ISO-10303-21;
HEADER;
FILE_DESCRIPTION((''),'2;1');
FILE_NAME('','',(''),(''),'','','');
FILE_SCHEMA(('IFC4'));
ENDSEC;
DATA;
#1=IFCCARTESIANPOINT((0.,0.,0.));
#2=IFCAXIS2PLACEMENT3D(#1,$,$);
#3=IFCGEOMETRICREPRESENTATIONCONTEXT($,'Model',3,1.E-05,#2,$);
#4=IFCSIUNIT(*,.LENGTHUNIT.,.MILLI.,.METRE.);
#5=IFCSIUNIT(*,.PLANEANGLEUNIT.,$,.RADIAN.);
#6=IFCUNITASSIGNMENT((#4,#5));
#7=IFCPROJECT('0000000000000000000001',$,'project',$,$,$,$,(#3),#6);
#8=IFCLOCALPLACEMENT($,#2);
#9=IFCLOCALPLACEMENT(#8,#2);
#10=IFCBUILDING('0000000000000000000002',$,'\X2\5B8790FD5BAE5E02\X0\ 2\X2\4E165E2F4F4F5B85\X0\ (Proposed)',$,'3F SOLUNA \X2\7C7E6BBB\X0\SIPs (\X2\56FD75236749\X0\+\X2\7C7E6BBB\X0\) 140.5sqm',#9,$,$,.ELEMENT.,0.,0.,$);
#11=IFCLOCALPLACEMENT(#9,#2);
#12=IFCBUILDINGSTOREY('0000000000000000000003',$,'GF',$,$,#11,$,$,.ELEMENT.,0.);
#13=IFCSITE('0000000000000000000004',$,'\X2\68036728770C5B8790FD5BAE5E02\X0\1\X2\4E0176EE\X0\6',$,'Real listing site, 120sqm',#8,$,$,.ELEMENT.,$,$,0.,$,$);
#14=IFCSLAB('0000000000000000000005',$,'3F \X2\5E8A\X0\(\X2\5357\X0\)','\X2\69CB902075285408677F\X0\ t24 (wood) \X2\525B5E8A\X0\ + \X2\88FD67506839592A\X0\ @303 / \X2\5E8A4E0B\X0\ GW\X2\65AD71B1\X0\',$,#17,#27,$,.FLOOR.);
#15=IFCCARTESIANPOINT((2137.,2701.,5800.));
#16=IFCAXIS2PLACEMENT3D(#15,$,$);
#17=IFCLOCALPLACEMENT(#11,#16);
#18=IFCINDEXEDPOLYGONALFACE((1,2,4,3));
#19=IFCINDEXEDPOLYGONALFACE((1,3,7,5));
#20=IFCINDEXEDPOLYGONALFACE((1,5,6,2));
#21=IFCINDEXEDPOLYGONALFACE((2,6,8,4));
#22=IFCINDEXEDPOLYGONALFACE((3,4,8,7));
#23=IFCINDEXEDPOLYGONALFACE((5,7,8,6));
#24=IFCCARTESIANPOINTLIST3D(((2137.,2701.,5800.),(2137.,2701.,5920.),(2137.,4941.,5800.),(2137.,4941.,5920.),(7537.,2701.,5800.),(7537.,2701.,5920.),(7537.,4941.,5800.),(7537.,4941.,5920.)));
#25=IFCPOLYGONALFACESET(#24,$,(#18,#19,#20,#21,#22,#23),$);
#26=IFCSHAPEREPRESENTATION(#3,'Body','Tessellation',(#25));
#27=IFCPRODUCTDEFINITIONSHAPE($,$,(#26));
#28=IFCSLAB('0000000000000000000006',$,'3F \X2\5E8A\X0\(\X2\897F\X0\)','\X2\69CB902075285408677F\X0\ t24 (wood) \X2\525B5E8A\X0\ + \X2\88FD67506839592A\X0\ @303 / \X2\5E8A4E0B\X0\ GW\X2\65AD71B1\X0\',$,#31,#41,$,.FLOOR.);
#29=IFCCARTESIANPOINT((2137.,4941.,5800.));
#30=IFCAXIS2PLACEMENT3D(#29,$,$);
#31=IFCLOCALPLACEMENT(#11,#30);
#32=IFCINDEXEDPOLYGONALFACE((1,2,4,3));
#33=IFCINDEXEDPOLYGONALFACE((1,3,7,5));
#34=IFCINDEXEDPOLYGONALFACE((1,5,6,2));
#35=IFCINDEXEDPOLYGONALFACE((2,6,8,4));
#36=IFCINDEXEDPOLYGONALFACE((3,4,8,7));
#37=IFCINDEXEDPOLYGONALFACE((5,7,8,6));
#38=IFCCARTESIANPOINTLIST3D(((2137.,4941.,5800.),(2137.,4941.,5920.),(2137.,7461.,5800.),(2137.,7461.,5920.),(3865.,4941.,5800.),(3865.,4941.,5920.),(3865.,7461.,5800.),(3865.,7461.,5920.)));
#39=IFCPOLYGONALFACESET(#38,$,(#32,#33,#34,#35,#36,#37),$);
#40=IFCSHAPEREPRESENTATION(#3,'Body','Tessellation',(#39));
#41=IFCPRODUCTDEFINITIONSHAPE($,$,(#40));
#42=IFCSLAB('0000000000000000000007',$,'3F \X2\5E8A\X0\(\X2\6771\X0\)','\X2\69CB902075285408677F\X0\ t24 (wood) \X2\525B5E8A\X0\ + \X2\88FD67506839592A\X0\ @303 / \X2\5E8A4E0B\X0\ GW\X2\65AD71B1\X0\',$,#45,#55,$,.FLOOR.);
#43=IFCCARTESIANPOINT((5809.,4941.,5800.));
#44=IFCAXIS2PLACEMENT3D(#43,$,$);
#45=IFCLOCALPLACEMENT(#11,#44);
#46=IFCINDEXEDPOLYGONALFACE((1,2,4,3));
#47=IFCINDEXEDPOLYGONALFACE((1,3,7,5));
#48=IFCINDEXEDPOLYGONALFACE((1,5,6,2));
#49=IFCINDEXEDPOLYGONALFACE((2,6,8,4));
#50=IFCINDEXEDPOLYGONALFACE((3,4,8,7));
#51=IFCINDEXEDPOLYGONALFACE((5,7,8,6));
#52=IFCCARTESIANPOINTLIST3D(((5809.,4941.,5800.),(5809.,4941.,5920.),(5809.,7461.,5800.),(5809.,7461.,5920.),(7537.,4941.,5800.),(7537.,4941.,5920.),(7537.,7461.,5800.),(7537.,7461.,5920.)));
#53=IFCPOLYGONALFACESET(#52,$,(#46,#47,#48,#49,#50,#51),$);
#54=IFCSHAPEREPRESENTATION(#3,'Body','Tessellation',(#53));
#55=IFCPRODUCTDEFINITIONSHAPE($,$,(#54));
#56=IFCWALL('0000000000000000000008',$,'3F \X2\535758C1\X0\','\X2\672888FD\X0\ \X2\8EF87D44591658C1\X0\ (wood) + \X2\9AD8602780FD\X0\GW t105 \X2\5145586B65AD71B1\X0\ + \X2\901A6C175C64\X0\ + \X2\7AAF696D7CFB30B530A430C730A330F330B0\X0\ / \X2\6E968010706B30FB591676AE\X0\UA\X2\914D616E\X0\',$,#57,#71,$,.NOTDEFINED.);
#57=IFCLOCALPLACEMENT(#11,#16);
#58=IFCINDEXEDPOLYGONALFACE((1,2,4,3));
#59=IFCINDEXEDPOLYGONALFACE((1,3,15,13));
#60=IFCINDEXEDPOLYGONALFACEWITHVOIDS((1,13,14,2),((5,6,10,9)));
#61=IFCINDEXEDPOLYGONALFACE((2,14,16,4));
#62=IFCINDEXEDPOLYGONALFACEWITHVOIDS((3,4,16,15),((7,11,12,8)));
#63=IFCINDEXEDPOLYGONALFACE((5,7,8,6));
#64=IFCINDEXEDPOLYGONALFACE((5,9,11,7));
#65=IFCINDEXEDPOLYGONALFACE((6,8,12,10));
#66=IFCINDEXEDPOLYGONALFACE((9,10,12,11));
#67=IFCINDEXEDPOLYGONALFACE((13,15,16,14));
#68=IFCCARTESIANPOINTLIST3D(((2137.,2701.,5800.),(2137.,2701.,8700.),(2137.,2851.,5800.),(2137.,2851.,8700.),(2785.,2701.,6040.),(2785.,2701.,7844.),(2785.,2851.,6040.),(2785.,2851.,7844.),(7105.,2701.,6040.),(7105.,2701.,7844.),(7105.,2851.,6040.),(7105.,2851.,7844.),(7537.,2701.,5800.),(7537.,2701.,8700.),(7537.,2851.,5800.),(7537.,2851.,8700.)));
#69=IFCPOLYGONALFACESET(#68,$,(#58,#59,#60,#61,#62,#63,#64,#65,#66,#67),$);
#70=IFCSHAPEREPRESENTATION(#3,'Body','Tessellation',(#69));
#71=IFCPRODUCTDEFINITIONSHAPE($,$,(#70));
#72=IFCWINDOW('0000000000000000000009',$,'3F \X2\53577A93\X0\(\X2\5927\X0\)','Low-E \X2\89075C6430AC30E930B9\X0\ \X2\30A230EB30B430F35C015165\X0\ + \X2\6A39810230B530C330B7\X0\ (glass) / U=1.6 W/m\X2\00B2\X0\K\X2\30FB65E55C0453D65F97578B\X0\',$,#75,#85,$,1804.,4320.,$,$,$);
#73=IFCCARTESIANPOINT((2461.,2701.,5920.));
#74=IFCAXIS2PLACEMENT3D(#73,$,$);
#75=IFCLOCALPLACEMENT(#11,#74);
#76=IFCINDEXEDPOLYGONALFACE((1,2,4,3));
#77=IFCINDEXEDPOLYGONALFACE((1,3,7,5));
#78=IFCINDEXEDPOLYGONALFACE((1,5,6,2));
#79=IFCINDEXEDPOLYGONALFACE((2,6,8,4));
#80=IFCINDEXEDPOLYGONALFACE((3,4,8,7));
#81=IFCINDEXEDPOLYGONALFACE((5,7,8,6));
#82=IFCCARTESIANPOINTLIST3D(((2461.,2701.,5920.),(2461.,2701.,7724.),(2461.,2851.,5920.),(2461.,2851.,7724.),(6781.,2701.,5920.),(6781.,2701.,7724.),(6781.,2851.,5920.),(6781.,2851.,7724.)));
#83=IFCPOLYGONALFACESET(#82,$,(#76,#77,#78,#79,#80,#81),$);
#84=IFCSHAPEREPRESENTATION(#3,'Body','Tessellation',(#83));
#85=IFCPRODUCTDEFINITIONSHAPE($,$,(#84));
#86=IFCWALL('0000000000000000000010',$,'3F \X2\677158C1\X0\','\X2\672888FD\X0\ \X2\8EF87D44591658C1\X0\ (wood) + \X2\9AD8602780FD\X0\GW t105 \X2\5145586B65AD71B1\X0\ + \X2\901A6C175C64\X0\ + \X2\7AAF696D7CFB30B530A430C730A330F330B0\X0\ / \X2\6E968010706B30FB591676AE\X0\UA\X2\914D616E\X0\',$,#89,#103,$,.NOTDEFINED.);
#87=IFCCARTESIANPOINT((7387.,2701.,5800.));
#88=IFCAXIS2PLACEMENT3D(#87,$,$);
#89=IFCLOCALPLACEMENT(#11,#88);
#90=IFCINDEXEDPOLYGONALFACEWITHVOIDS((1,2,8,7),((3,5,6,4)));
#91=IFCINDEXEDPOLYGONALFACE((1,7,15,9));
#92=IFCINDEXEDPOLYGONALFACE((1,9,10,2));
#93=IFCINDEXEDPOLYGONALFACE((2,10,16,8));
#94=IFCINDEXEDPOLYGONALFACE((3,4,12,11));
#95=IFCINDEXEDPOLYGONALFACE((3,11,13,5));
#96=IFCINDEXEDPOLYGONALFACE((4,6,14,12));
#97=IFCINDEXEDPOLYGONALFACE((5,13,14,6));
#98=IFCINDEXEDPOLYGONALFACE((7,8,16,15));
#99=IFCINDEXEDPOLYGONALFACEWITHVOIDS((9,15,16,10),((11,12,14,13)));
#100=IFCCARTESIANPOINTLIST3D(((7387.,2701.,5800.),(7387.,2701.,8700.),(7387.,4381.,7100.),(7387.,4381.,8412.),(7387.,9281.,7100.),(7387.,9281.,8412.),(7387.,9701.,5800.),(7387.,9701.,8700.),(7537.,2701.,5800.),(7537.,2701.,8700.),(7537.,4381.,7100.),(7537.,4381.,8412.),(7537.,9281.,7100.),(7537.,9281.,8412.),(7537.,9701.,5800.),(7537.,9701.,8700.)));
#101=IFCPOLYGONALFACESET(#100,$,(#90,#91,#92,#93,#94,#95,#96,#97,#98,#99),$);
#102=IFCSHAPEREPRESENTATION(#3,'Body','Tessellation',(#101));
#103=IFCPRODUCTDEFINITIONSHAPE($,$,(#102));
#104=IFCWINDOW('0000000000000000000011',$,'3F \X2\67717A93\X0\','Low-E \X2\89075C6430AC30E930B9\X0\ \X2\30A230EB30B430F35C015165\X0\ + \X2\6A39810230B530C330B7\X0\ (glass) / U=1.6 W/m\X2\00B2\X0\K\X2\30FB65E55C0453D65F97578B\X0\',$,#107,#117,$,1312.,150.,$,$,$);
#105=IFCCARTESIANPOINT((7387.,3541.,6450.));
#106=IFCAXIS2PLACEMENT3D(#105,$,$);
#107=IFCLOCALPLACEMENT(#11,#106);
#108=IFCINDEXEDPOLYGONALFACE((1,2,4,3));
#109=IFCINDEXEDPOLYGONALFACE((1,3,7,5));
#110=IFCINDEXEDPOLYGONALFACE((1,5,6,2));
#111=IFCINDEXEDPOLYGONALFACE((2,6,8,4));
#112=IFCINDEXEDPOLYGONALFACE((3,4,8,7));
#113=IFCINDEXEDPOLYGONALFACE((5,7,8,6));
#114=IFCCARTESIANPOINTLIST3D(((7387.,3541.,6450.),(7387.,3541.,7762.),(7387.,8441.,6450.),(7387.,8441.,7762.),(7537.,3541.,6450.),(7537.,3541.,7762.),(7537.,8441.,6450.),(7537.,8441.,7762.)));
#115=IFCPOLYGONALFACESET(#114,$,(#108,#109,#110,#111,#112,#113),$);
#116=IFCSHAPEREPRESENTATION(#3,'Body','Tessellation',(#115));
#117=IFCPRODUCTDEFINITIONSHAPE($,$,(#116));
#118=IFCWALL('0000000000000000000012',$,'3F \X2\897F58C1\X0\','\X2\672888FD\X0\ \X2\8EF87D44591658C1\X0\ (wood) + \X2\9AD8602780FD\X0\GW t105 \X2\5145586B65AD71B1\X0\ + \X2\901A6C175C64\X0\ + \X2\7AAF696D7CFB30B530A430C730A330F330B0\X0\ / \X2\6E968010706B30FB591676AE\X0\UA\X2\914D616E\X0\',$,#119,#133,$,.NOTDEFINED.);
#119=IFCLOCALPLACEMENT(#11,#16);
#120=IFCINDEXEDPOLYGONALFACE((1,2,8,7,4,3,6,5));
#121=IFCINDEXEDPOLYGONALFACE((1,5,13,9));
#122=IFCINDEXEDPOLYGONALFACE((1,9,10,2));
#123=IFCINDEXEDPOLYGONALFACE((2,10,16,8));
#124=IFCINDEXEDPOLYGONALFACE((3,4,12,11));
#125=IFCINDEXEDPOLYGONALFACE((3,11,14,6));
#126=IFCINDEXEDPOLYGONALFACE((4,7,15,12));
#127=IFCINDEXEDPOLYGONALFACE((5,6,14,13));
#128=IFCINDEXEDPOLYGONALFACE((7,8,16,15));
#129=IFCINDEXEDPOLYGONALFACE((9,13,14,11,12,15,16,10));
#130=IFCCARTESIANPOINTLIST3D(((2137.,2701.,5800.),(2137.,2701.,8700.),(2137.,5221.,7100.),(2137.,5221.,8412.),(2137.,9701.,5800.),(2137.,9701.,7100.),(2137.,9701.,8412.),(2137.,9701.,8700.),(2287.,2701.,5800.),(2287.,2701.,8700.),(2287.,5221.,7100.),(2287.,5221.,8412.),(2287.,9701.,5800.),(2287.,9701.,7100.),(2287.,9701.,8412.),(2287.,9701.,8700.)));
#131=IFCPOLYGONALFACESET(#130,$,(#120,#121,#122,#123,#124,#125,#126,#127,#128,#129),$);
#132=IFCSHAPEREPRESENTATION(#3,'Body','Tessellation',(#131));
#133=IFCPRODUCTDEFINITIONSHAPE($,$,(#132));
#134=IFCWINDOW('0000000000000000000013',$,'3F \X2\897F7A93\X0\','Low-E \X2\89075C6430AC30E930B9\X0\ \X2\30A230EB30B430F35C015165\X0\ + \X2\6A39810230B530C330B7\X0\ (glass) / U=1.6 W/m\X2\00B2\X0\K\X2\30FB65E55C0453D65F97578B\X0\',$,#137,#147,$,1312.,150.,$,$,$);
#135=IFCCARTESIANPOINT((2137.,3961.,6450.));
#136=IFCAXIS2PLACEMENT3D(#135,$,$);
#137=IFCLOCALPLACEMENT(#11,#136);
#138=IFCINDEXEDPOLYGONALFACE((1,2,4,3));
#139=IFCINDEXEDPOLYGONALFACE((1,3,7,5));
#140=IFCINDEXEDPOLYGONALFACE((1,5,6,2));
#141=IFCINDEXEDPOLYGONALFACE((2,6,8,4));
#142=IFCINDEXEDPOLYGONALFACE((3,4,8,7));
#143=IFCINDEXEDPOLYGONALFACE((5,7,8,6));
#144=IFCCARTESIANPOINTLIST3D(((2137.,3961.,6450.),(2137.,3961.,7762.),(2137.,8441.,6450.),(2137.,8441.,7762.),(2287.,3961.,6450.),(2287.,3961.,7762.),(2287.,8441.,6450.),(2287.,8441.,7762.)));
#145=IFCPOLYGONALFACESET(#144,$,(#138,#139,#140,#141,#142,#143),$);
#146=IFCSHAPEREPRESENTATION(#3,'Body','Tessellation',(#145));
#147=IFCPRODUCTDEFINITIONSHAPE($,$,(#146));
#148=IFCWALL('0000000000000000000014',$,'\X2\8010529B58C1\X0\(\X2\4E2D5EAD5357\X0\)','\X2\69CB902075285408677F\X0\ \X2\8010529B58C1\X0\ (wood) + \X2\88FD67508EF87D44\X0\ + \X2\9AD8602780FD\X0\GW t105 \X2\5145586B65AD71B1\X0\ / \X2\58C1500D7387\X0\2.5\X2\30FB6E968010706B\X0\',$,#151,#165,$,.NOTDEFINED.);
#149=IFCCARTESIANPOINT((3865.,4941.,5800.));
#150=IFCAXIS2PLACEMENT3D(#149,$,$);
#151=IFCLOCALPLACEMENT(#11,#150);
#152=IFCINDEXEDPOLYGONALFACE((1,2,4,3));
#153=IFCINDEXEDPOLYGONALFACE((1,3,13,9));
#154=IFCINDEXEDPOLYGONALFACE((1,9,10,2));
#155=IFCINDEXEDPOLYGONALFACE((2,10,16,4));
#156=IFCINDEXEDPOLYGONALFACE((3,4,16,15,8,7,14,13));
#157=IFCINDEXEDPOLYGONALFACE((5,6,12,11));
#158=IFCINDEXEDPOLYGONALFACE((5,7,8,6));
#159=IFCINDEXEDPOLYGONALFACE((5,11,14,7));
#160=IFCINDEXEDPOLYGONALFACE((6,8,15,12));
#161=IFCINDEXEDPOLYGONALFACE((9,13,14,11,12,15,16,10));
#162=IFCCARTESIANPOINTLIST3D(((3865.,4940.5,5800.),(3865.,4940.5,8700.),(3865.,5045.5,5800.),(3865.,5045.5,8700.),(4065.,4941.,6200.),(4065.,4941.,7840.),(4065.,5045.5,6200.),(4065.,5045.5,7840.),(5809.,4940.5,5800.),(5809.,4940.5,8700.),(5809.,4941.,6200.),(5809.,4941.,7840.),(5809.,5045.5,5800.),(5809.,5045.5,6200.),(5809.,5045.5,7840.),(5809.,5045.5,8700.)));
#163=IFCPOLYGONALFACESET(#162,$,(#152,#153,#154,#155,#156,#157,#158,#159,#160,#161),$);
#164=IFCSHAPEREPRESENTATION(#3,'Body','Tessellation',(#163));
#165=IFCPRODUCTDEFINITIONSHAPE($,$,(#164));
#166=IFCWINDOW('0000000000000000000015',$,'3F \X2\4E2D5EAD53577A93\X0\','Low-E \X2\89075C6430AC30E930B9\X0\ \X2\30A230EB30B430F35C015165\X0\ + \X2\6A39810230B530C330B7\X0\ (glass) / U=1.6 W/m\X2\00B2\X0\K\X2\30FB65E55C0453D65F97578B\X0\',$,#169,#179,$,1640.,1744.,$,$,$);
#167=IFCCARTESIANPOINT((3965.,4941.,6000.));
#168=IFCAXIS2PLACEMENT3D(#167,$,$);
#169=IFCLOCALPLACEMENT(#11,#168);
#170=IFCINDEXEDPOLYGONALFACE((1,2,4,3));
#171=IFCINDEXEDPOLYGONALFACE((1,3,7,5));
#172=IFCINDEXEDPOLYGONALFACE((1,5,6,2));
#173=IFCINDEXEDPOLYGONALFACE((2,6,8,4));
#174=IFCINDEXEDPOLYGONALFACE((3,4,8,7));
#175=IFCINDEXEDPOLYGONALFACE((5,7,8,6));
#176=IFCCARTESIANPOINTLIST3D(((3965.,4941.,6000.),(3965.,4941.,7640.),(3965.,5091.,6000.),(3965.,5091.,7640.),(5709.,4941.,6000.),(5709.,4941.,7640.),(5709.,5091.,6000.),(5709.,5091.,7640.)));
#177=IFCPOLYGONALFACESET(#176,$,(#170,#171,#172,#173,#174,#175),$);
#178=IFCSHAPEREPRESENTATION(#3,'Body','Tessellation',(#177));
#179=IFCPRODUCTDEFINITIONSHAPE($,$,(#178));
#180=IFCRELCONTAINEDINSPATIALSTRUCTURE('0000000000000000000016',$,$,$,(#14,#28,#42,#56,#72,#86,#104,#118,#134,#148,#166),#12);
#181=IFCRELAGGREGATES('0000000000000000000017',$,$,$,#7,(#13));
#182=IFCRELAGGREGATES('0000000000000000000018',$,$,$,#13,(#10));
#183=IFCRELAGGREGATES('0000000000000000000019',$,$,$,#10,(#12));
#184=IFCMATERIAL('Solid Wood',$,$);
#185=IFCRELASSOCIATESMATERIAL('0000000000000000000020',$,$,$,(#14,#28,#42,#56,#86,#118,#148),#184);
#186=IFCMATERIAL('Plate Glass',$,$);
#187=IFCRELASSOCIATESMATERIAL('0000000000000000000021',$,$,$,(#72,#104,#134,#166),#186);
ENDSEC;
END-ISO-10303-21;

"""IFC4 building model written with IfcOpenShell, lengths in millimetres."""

from ifc_helpers import new_model, si_unit, frame, frame_2d, origin, place, context, project, spatial, rectangle, extrude, material, element, fill, save


model = new_model("IFC4")

# Units and contexts
model_context = context("Model", 3, precision=1e-05, world=origin())
ifc_project = project(units=[si_unit("LENGTHUNIT", "METRE", prefix="MILLI"), si_unit("PLANEANGLEUNIT", "RADIAN")], contexts=[model_context])

# Site, building, storey
site_placement = place(None, origin())
site = spatial("IfcSite", under=ifc_project, at=site_placement, Name="栃木県宇都宮市1丁目6", ObjectType="Real listing site, 120sqm", CompositionType="ELEMENT", RefElevation=0.0)
building_placement = place(site_placement, origin())
building = spatial("IfcBuilding", under=site, at=building_placement, Name="宇都宮市 2世帯住宅 (Proposed)", ObjectType="3F SOLUNA 籾殻SIPs (国産杉+籾殻) 140.5sqm", CompositionType="ELEMENT", ElevationOfRefHeight=0.0, ElevationOfTerrain=0.0)
storey_placement = place(building_placement, origin())
storey = spatial("IfcBuildingStorey", under=building, at=storey_placement, Name="GF", CompositionType="ELEMENT", Elevation=0.0)

# Slabs
ifc_material_1 = material(Name="Solid Wood")
slab_1_placement = place(storey_placement, frame((2137.0, 2701.0, 5800.0)))
element("IfcSlab", 1, at=slab_1_placement, inside=storey, material=ifc_material_1, Name="3F 床(南)", Description="構造用合板 t24 (wood) 剛床 + 製材根太 @303 / 床下 GW断熱", PredefinedType="FLOOR", context=model_context, shape_type="SweptSolid", body=[
    extrude(rectangle(XDim=5400.0, YDim=2240.0, at=frame_2d((2700.0, 1120.0))), frame((2137.0, 2701.0, 5800.0)), (0.0, 0.0, 1.0), 120.0),
])
slab_2_placement = place(storey_placement, frame((2137.0, 4941.0, 5800.0)))
element("IfcSlab", 2, at=slab_2_placement, inside=storey, material=ifc_material_1, Name="3F 床(西)", Description="構造用合板 t24 (wood) 剛床 + 製材根太 @303 / 床下 GW断熱", PredefinedType="FLOOR", context=model_context, shape_type="SweptSolid", body=[
    extrude(rectangle(XDim=1728.0, YDim=2520.0, at=frame_2d((864.0, 1260.0))), frame((2137.0, 4941.0, 5800.0)), (0.0, 0.0, 1.0), 120.0),
])
slab_3_placement = place(storey_placement, frame((5809.0, 4941.0, 5800.0)))
element("IfcSlab", 3, at=slab_3_placement, inside=storey, material=ifc_material_1, Name="3F 床(東)", Description="構造用合板 t24 (wood) 剛床 + 製材根太 @303 / 床下 GW断熱", PredefinedType="FLOOR", context=model_context, shape_type="SweptSolid", body=[
    extrude(rectangle(XDim=1728.0, YDim=2520.0, at=frame_2d((864.0, 1260.0))), frame((5809.0, 4941.0, 5800.0)), (0.0, 0.0, 1.0), 120.0),
])

# Walls, openings, windows
wall_1_placement = place(storey_placement, frame((2137.0, 2701.0, 5800.0)))
wall_1 = element("IfcWall", 4, at=wall_1_placement, inside=storey, material=ifc_material_1, Name="3F 南壁", Description="木製 軸組外壁 (wood) + 高性能GW t105 充填断熱 + 通気層 + 窯業系サイディング / 準耐火・外皮UA配慮", PredefinedType="NOTDEFINED", context=model_context, shape_type="SweptSolid", body=[
    extrude(rectangle(XDim=5400.0, YDim=150.0, at=frame_2d((2700.0, 75.0))), frame((2137.0, 2701.0, 5800.0)), (0.0, 0.0, 1.0), 2900.0),
])
opening_1_placement = place(storey_placement, frame((2461.0, 2701.0, 5920.0)))
opening_1 = element("IfcOpeningElement", 5, at=opening_1_placement, cuts=wall_1, PredefinedType="NOTDEFINED", context=model_context, shape_type="SweptSolid", body=[
    extrude(rectangle(XDim=4320.0, YDim=150.0, at=frame_2d((2160.0, 75.0))), frame((2461.0, 2701.0, 5920.0)), (0.0, 0.0, 1.0), 1804.0),
])
ifc_material_2 = material(Name="Plate Glass")
window_1_placement = place(storey_placement, frame((2461.0, 2701.0, 5920.0)))
window_1 = element("IfcWindow", 6, at=window_1_placement, inside=storey, material=ifc_material_2, Name="3F 南窓(大)", Description="Low-E 複層ガラス アルゴン封入 + 樹脂サッシ (glass) / U=1.6 W/m²K・日射取得型", OverallHeight=1804.0, OverallWidth=4320.0, context=model_context, shape_type="SweptSolid", body=[
    extrude(rectangle(XDim=4320.0, YDim=150.0, at=frame_2d((2160.0, 75.0))), frame((2461.0, 2701.0, 5920.0)), (0.0, 0.0, 1.0), 1804.0),
])
fill(opening_1, window_1)
wall_2_placement = place(storey_placement, frame((7387.0, 2701.0, 5800.0)))
wall_2 = element("IfcWall", 7, at=wall_2_placement, inside=storey, material=ifc_material_1, Name="3F 東壁", Description="木製 軸組外壁 (wood) + 高性能GW t105 充填断熱 + 通気層 + 窯業系サイディング / 準耐火・外皮UA配慮", PredefinedType="NOTDEFINED", context=model_context, shape_type="SweptSolid", body=[
    extrude(rectangle(XDim=150.0, YDim=7000.0, at=frame_2d((75.0, 3500.0))), frame((7387.0, 2701.0, 5800.0)), (0.0, 0.0, 1.0), 2900.0),
])
opening_2_placement = place(storey_placement, frame((7387.0, 3541.0, 6450.0)))
opening_2 = element("IfcOpeningElement", 8, at=opening_2_placement, cuts=wall_2, PredefinedType="NOTDEFINED", context=model_context, shape_type="SweptSolid", body=[
    extrude(rectangle(XDim=150.0, YDim=4900.0, at=frame_2d((75.0, 2450.0))), frame((7387.0, 3541.0, 6450.0)), (0.0, 0.0, 1.0), 1312.0),
])
window_2_placement = place(storey_placement, frame((7387.0, 3541.0, 6450.0)))
window_2 = element("IfcWindow", 9, at=window_2_placement, inside=storey, material=ifc_material_2, Name="3F 東窓", Description="Low-E 複層ガラス アルゴン封入 + 樹脂サッシ (glass) / U=1.6 W/m²K・日射取得型", OverallHeight=1312.0, OverallWidth=150.0, context=model_context, shape_type="SweptSolid", body=[
    extrude(rectangle(XDim=150.0, YDim=4900.0, at=frame_2d((75.0, 2450.0))), frame((7387.0, 3541.0, 6450.0)), (0.0, 0.0, 1.0), 1312.0),
])
fill(opening_2, window_2)
wall_3_placement = place(storey_placement, frame((2137.0, 2701.0, 5800.0)))
wall_3 = element("IfcWall", 10, at=wall_3_placement, inside=storey, material=ifc_material_1, Name="3F 西壁", Description="木製 軸組外壁 (wood) + 高性能GW t105 充填断熱 + 通気層 + 窯業系サイディング / 準耐火・外皮UA配慮", PredefinedType="NOTDEFINED", context=model_context, shape_type="SweptSolid", body=[
    extrude(rectangle(XDim=150.0, YDim=7000.0, at=frame_2d((75.0, 3500.0))), frame((2137.0, 2701.0, 5800.0)), (0.0, 0.0, 1.0), 2900.0),
])
opening_3_placement = place(storey_placement, frame((2137.0, 3961.0, 6450.0)))
opening_3 = element("IfcOpeningElement", 11, at=opening_3_placement, cuts=wall_3, PredefinedType="NOTDEFINED", context=model_context, shape_type="SweptSolid", body=[
    extrude(rectangle(XDim=150.0, YDim=4480.0, at=frame_2d((75.0, 2240.0))), frame((2137.0, 3961.0, 6450.0)), (0.0, 0.0, 1.0), 1312.0),
])
window_3_placement = place(storey_placement, frame((2137.0, 3961.0, 6450.0)))
window_3 = element("IfcWindow", 12, at=window_3_placement, inside=storey, material=ifc_material_2, Name="3F 西窓", Description="Low-E 複層ガラス アルゴン封入 + 樹脂サッシ (glass) / U=1.6 W/m²K・日射取得型", OverallHeight=1312.0, OverallWidth=150.0, context=model_context, shape_type="SweptSolid", body=[
    extrude(rectangle(XDim=150.0, YDim=4480.0, at=frame_2d((75.0, 2240.0))), frame((2137.0, 3961.0, 6450.0)), (0.0, 0.0, 1.0), 1312.0),
])
fill(opening_3, window_3)
wall_4_placement = place(storey_placement, frame((3865.0, 4941.0, 5800.0)))
wall_4 = element("IfcWall", 13, at=wall_4_placement, inside=storey, material=ifc_material_1, Name="耐力壁(中庭南)", Description="構造用合板 耐力壁 (wood) + 製材軸組 + 高性能GW t105 充填断熱 / 壁倍率2.5・準耐火", PredefinedType="NOTDEFINED", context=model_context, shape_type="SweptSolid", body=[
    extrude(rectangle(XDim=1944.0, YDim=105.0, at=frame_2d((972.0, 52.0))), frame((3865.0, 4941.0, 5800.0)), (0.0, 0.0, 1.0), 2900.0),
])
opening_4_placement = place(storey_placement, frame((3965.0, 4941.0, 6000.0)))
opening_4 = element("IfcOpeningElement", 14, at=opening_4_placement, cuts=wall_4, PredefinedType="NOTDEFINED", context=model_context, shape_type="SweptSolid", body=[
    extrude(rectangle(XDim=1744.0, YDim=150.0, at=frame_2d((872.0, 75.0))), frame((3965.0, 4941.0, 6000.0)), (0.0, 0.0, 1.0), 1640.0),
])
window_4_placement = place(storey_placement, frame((3965.0, 4941.0, 6000.0)))
window_4 = element("IfcWindow", 15, at=window_4_placement, inside=storey, material=ifc_material_2, Name="3F 中庭南窓", Description="Low-E 複層ガラス アルゴン封入 + 樹脂サッシ (glass) / U=1.6 W/m²K・日射取得型", OverallHeight=1640.0, OverallWidth=1744.0, context=model_context, shape_type="SweptSolid", body=[
    extrude(rectangle(XDim=1744.0, YDim=150.0, at=frame_2d((872.0, 75.0))), frame((3965.0, 4941.0, 6000.0)), (0.0, 0.0, 1.0), 1640.0),
])
fill(opening_4, window_4)

save(model, "model.ifc")
